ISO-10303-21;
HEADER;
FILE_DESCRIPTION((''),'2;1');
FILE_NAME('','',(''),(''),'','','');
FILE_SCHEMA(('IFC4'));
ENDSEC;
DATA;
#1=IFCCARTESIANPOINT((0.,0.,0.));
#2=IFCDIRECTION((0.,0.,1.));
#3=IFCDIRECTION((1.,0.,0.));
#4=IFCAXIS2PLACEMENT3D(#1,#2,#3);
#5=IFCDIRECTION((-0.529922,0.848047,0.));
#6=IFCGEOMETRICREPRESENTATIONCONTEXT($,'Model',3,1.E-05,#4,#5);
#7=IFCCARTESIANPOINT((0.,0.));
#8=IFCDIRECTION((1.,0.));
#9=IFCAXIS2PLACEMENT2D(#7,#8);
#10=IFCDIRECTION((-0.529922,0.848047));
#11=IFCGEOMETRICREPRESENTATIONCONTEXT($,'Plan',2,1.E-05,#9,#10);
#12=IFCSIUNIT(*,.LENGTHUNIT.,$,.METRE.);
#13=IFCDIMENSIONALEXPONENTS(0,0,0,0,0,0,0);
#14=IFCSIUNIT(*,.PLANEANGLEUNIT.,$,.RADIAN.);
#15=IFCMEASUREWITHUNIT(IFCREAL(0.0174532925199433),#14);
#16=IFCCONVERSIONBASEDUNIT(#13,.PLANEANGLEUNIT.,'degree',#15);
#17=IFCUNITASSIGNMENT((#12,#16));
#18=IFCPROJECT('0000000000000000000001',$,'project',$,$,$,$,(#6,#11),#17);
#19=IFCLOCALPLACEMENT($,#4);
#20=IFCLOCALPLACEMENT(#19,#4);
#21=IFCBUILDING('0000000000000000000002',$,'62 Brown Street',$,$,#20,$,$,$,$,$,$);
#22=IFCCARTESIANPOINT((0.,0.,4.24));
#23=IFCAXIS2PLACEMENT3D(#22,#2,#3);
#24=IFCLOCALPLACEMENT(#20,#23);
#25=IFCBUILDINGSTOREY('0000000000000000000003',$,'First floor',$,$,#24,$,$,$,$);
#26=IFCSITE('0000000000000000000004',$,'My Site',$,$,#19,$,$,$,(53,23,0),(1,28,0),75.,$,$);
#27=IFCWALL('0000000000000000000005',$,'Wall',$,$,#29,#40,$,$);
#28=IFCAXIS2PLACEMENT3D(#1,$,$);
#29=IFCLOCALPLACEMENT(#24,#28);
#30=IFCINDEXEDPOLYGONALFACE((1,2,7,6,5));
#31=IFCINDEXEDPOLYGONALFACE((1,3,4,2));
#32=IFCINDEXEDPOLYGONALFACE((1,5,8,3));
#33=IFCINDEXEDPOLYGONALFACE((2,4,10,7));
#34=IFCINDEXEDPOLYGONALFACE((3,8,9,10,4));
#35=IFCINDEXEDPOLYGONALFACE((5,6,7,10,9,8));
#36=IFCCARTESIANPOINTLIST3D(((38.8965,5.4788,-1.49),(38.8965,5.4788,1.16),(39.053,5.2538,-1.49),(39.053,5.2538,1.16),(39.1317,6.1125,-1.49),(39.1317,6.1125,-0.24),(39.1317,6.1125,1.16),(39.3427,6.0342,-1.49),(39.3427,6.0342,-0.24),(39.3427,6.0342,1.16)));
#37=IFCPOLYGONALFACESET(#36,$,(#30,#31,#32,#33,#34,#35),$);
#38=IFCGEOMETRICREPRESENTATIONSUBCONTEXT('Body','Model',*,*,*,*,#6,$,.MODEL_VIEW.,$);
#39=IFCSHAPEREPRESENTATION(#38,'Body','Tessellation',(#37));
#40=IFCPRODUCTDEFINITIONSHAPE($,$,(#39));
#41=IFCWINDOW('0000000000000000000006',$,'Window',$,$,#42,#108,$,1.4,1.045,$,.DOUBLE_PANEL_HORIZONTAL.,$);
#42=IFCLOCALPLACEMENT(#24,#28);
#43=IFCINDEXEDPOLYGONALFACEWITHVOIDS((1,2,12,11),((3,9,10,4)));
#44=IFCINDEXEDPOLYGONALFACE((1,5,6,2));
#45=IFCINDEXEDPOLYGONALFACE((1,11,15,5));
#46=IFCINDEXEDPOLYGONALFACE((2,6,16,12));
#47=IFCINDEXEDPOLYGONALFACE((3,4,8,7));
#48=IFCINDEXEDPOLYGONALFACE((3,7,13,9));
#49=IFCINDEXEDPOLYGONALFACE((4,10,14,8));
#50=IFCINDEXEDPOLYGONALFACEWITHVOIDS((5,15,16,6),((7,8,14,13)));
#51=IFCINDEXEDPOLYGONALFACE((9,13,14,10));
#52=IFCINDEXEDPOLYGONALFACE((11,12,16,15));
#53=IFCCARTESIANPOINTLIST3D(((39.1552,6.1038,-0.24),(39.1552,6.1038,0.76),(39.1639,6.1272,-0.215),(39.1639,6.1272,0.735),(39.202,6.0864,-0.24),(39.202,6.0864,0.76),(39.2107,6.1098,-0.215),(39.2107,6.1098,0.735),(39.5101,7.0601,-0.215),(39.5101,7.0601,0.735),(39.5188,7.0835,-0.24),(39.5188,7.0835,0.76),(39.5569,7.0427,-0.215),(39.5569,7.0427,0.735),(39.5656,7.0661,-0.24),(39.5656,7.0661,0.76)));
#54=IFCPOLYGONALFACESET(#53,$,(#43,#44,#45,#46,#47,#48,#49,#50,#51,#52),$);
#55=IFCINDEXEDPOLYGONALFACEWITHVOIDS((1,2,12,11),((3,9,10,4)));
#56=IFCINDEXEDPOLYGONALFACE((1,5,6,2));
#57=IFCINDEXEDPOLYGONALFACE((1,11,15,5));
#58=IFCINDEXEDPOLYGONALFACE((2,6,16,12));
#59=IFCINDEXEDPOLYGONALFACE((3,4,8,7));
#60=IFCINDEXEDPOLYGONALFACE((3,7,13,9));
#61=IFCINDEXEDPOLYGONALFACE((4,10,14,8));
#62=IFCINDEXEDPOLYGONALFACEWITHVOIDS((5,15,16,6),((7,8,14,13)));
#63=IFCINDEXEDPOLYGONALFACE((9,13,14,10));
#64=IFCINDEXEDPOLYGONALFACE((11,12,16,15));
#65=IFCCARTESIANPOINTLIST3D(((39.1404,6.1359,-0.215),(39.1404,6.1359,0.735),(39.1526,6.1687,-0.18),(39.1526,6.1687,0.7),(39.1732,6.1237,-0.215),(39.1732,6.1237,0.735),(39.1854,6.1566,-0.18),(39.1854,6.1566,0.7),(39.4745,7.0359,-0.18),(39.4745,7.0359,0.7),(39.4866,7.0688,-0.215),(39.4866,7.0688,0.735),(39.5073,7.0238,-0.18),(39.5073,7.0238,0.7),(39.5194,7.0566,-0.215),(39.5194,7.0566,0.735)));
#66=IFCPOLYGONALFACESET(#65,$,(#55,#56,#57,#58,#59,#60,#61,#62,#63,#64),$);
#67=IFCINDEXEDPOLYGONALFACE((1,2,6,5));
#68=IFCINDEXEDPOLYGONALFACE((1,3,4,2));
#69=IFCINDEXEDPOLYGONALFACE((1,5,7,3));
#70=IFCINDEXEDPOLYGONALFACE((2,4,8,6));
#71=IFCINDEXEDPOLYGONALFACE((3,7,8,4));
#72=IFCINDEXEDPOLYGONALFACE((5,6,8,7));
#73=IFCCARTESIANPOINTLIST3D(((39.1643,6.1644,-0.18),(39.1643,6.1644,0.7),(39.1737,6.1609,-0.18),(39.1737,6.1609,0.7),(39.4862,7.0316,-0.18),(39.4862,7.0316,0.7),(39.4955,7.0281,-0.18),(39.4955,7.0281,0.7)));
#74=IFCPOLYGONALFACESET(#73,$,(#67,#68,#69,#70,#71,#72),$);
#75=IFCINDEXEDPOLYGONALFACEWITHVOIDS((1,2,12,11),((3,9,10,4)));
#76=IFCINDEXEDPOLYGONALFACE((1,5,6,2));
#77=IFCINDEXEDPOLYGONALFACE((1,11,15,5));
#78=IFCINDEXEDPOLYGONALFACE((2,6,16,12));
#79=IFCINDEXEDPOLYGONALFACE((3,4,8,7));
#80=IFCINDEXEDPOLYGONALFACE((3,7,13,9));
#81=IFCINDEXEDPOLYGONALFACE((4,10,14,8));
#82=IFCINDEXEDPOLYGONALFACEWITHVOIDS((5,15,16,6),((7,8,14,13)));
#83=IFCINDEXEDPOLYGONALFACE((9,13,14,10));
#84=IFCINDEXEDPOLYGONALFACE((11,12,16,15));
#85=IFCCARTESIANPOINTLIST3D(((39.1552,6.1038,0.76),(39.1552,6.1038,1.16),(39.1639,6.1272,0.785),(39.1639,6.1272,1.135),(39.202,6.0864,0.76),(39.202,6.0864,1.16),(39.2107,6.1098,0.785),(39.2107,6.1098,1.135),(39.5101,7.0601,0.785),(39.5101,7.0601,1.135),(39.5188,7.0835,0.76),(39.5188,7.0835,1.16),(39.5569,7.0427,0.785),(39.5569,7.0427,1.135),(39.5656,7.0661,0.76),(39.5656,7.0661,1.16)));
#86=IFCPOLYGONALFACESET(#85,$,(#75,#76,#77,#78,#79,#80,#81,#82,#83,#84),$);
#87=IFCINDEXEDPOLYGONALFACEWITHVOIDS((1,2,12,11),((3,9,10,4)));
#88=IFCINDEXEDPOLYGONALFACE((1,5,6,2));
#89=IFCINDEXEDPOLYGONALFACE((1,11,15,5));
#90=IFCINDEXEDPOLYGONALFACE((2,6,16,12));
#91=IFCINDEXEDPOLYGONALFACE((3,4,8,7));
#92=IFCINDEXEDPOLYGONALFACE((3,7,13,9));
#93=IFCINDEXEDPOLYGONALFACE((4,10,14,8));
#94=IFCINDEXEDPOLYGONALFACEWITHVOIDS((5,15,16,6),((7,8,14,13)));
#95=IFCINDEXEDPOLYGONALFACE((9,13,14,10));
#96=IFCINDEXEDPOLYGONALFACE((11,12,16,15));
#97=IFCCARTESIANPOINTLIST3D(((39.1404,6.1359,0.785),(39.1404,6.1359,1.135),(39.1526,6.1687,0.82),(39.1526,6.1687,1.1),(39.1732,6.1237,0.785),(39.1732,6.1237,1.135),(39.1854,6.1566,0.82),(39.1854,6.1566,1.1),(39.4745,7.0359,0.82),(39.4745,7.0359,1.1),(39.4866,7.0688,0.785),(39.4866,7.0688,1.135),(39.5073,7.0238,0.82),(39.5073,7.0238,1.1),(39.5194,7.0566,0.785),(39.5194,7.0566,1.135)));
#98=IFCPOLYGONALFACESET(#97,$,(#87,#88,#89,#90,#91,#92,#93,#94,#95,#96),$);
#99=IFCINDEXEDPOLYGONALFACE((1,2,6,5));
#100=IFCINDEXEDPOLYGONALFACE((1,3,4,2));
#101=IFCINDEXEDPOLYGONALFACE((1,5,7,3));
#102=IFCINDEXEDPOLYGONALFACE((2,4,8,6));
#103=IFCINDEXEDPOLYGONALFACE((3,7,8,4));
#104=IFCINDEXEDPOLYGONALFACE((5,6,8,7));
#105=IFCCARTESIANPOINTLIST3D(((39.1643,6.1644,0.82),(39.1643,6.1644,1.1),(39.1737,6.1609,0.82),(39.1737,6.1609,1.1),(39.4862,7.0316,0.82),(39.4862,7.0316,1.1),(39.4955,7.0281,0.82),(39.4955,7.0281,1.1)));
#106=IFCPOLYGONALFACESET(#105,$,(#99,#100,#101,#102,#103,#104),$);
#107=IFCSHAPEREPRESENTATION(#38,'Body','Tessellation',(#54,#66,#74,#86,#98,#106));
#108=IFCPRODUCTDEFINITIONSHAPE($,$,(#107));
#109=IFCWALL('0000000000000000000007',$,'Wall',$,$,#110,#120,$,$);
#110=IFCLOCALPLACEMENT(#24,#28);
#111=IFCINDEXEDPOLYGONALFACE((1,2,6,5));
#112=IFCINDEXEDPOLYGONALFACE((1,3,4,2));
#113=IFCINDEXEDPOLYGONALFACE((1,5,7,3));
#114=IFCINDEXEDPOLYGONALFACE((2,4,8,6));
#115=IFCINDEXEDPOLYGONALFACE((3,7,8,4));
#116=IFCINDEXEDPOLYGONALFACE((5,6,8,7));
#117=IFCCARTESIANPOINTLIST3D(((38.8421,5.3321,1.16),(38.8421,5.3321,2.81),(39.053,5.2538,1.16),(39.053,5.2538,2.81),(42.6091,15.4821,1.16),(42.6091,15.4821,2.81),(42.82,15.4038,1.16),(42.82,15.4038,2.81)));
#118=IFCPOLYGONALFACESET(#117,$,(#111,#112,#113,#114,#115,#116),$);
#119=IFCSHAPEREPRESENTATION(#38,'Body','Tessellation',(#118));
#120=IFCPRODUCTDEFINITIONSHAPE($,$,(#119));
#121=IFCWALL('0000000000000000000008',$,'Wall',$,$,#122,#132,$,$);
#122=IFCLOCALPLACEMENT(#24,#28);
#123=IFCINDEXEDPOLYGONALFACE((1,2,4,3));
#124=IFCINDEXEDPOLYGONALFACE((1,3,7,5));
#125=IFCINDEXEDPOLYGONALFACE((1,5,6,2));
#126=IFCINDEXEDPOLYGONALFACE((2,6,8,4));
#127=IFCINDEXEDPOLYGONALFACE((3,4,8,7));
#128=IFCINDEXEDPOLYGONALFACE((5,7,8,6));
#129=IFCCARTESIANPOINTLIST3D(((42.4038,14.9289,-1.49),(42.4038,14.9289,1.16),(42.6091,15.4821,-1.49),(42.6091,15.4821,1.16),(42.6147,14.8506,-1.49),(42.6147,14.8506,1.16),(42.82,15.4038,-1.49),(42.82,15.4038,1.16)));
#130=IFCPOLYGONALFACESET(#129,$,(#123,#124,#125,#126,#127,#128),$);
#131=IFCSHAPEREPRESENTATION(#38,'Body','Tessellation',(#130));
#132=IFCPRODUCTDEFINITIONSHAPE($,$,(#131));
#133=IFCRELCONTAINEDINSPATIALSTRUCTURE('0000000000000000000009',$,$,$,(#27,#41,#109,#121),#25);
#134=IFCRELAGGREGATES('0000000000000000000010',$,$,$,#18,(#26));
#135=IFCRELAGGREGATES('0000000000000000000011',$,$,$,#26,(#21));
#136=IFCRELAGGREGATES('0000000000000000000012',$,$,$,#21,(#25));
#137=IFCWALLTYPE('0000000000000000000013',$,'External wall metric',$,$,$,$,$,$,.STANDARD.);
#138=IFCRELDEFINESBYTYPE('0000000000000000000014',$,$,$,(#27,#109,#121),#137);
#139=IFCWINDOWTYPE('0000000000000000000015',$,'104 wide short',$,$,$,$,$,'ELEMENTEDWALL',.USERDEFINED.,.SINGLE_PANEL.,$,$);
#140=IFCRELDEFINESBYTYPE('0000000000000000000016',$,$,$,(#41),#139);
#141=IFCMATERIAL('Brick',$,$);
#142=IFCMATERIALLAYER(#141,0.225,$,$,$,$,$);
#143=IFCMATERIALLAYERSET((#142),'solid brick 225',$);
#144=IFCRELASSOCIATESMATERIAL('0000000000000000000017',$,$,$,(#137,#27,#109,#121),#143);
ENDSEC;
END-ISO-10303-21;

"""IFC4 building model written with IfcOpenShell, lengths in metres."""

from ifc_helpers import new_model, entity, si_unit, converted_unit, direction, frame, origin_with_axes, origin_2d_with_axis, place, context, subcontext, project, spatial, line, indexed_curve, outline, extrude, clip, halfspace, shape, source, transform, mapped, material, layer, layer_set, layer_usage, type_object, type_shapes, element, fill, save


model = new_model("IFC4")

# Units and contexts
model_context = context("Model", 3, precision=1e-05, world=origin_with_axes(), true_north=direction((-0.529922, 0.848047, 0.0)))
plan_context = context("Plan", 2, precision=1e-05, world=origin_2d_with_axis(), true_north=direction((-0.529922, 0.848047)))
body_context_1 = subcontext(model_context, "Body", "Model", "MODEL_VIEW")
body_context_2 = subcontext(plan_context, "Body", "Plan", "PLAN_VIEW")
ifc_project = project(units=[si_unit("LENGTHUNIT", "METRE"), converted_unit("PLANEANGLEUNIT", "degree", entity("IfcReal", 0.0174532925199433), si_unit("PLANEANGLEUNIT", "RADIAN"), dimensions=[0, 0, 0, 0, 0, 0, 0])], contexts=[model_context, plan_context])

# Site, building, storey
site_placement = place(None, origin_with_axes())
site = spatial("IfcSite", under=ifc_project, at=site_placement, Name="My Site", RefLatitude=(53, 23, 0), RefLongitude=(1, 28, 0), RefElevation=75.0)
building_placement = place(site_placement, origin_with_axes())
building = spatial("IfcBuilding", under=site, at=building_placement, Name="62 Brown Street")
storey_placement = place(building_placement, frame((0.0, 0.0, 4.24), z_axis=(0.0, 0.0, 1.0), x_axis=(1.0, 0.0, 0.0)))
storey = spatial("IfcBuildingStorey", under=building, at=storey_placement, Name="First floor")

# Wall, opening, window
ifc_material_1 = material(Name="Brick")
ifc_layer_1 = layer(ifc_material_1, 0.225)
ifc_layer_set_1 = layer_set([ifc_layer_1], Name="solid brick 225")
ifc_layer_usage_1 = layer_usage(ifc_layer_set_1, "AXIS2", "POSITIVE", 0.0)
wall_type_1 = type_object("IfcWallType", Name="External wall metric", PredefinedType="STANDARD", material=ifc_layer_set_1)
wall_1_placement = place(storey_placement, frame((39.024, 5.1755, -1.49), z_axis=(0.0, 0.0, 1.0), x_axis=(0.347944, 0.937515, 0.0)))
wall_1 = element("IfcWall", 1, at=wall_1_placement, inside=storey, type_object=wall_type_1, material=ifc_layer_usage_1, Name="Wall", context=body_context_1, shape_type="Clipping", body=[
    clip(extrude(outline(indexed_curve([(0.0, 0.0), (0.0, 0.225), (0.9159, 0.225), (0.9159, 0.0), (0.0, 0.0)], self_intersect=False)), origin_with_axes(), (0.0, 0.0, 1.0), 2.65), halfspace(frame((0.0835, 0.0, -2.75), z_axis=(-0.596248, 0.414701, 0.0), x_axis=(0.156491, 0.224999, 0.0)), False)),
])
shared_shape_1 = source(origin_with_axes(), body_context_1, "Body", "SweptSolid", [
    extrude(outline(indexed_curve([(0.0, 0.0), (1.045, 0.0), (1.045, 1.4), (0.0, 1.4)], segments=[line(1, 2, 3, 4, 1)])), frame((0.0, -0.1, 0.0), z_axis=(0.0, -1.0, 0.0), x_axis=(1.0, 0.0, 0.0)), (0.0, 0.0, -1.0), 0.425),
])
opening_placement = place(wall_1_placement, frame((0.9159, 0.0, 1.25), z_axis=(0.0, 0.0, 1.0), x_axis=(1.0, 0.0, 0.0)))
opening = element("IfcOpeningElement", 2, at=opening_placement, cuts=wall_1, PredefinedType="OPENING", context=body_context_1, shape_type="MappedRepresentation", body=[
    mapped(shared_shape_1, transform((0.0, 0.0, 0.0), x_axis=(1.0, 0.0, 0.0), y_axis=(0.0, 1.0, 0.0), z_axis=(0.0, 0.0, 1.0), scale=1.0)),
])
window_type = type_object("IfcWindowType", Name="104 wide short", ElementType="ELEMENTEDWALL", PartitioningType="SINGLE_PANEL", PredefinedType="USERDEFINED")
shared_shape_2 = source(origin_with_axes(), body_context_1, "Body", "SweptSolid", [
    extrude(outline(indexed_curve([(0.0, 0.0), (1.045, 0.0), (1.045, 1.0), (0.0, 1.0)], segments=[line(1, 2, 3, 4, 1)]), holes=[indexed_curve([(0.025, 0.025), (1.02, 0.025), (1.02, 0.975), (0.025, 0.975)], segments=[line(1, 2, 3, 4, 1)])]), frame((0.0, 0.15, 0.0), z_axis=(0.0, -1.0, 0.0), x_axis=(1.0, 0.0, 0.0)), (0.0, 0.0, -1.0), 0.05),
    extrude(outline(indexed_curve([(0.0, 0.0), (0.995, 0.0), (0.995, 0.95), (0.0, 0.95)], segments=[line(1, 2, 3, 4, 1)]), holes=[indexed_curve([(0.035, 0.035), (0.96, 0.035), (0.96, 0.915), (0.035, 0.915)], segments=[line(1, 2, 3, 4, 1)])]), frame((0.025, 0.19, 0.025), z_axis=(0.0, -1.0, 0.0), x_axis=(1.0, 0.0, 0.0)), (0.0, 0.0, -1.0), 0.035),
    extrude(outline(indexed_curve([(0.035, 0.035), (0.96, 0.035), (0.96, 0.915), (0.035, 0.915)], segments=[line(1, 2, 3, 4, 1)])), frame((0.025, 0.2025, 0.025), z_axis=(0.0, -1.0, 0.0), x_axis=(1.0, 0.0, 0.0)), (0.0, 0.0, -1.0), 0.01),
    extrude(outline(indexed_curve([(0.0, 0.0), (1.045, 0.0), (1.045, 0.4), (0.0, 0.4)], segments=[line(1, 2, 3, 4, 1)]), holes=[indexed_curve([(0.025, 0.025), (1.02, 0.025), (1.02, 0.375), (0.025, 0.375)], segments=[line(1, 2, 3, 4, 1)])]), frame((0.0, 0.15, 1.0), z_axis=(0.0, -1.0, 0.0), x_axis=(1.0, 0.0, 0.0)), (0.0, 0.0, -1.0), 0.05),
    extrude(outline(indexed_curve([(0.0, 0.0), (0.995, 0.0), (0.995, 0.35), (0.0, 0.35)], segments=[line(1, 2, 3, 4, 1)]), holes=[indexed_curve([(0.035, 0.035), (0.96, 0.035), (0.96, 0.315), (0.035, 0.315)], segments=[line(1, 2, 3, 4, 1)])]), frame((0.025, 0.19, 1.025), z_axis=(0.0, -1.0, 0.0), x_axis=(1.0, 0.0, 0.0)), (0.0, 0.0, -1.0), 0.035),
    extrude(outline(indexed_curve([(0.035, 0.035), (0.96, 0.035), (0.96, 0.315), (0.035, 0.315)], segments=[line(1, 2, 3, 4, 1)])), frame((0.025, 0.2025, 1.025), z_axis=(0.0, -1.0, 0.0), x_axis=(1.0, 0.0, 0.0)), (0.0, 0.0, -1.0), 0.01),
])
shared_shape_3 = source(origin_with_axes(), body_context_2, "Body", "Curve2D", [
    entity("IfcIndexedPolyCurve", entity("IfcCartesianPointList2D", [[0.025, 0.15], [1.02, 0.15]])),
    entity("IfcIndexedPolyCurve", entity("IfcCartesianPointList2D", [[0.0, 0.2], [0.025, 0.2], [0.025, 0.15], [0.0, 0.15]]), [entity("IfcLineIndex", [1, 2, 3, 4, 1])]),
    entity("IfcIndexedPolyCurve", entity("IfcCartesianPointList2D", [[1.045, 0.2], [1.02, 0.2], [1.02, 0.15], [1.045, 0.15]]), [entity("IfcLineIndex", [1, 2, 3, 4, 1])]),
    entity("IfcIndexedPolyCurve", entity("IfcCartesianPointList2D", [[0.025, 0.19], [0.06, 0.19], [0.06, 0.225], [0.025, 0.225]]), [entity("IfcLineIndex", [1, 2, 3, 4, 1])]),
    entity("IfcIndexedPolyCurve", entity("IfcCartesianPointList2D", [[1.02, 0.19], [0.985, 0.19], [0.985, 0.225], [1.02, 0.225]]), [entity("IfcLineIndex", [1, 2, 3, 4, 1])]),
    entity("IfcIndexedPolyCurve", entity("IfcCartesianPointList2D", [[0.06, 0.19], [0.985, 0.19]])),
    entity("IfcIndexedPolyCurve", entity("IfcCartesianPointList2D", [[0.06, 0.225], [0.985, 0.225]])),
    entity("IfcIndexedPolyCurve", entity("IfcCartesianPointList2D", [[0.06, 0.2075], [0.985, 0.2075]])),
])
type_shapes(window_type, [shared_shape_2, shared_shape_3])
window_1_placement = place(opening_placement, frame((0.0, 0.0, 0.0), z_axis=(0.0, 0.0, 1.0), x_axis=(1.0, 0.0, 0.0)))
window_1 = element("IfcWindow", 3, at=window_1_placement, inside=storey, type_object=window_type, Name="Window", OverallHeight=1.4, OverallWidth=1.045, PartitioningType="DOUBLE_PANEL_HORIZONTAL", shapes=[
    shape(body_context_1, "Body", "MappedRepresentation", [mapped(shared_shape_2, transform((0.0, 0.0, 0.0), x_axis=(1.0, 0.0, 0.0), y_axis=(0.0, 1.0, 0.0), z_axis=(0.0, 0.0, 1.0), scale=1.0))]),
    shape(body_context_2, "Body", "MappedRepresentation", [mapped(shared_shape_3, transform((0.0, 0.0, 0.0), x_axis=(1.0, 0.0, 0.0), y_axis=(0.0, 1.0, 0.0), z_axis=(0.0, 0.0, 1.0), scale=1.0))]),
])
fill(opening, window_1)

# Walls
ifc_layer_usage_2 = layer_usage(ifc_layer_set_1, "AXIS2", "POSITIVE", 0.0)
wall_2_placement = place(storey_placement, frame((39.053, 5.2538, 1.16), z_axis=(0.0, 0.0, 1.0), x_axis=(0.347944, 0.937515, 0.0)))
element("IfcWall", 4, at=wall_2_placement, inside=storey, type_object=wall_type_1, material=ifc_layer_usage_2, Name="Wall", context=body_context_1, shape_type="SweptSolid", body=[
    extrude(outline(indexed_curve([(0.0, 0.0), (0.0, 0.225), (10.8265, 0.225), (10.8265, 0.0), (0.0, 0.0)], self_intersect=False)), origin_with_axes(), (0.0, 0.0, 1.0), 1.65),
])
ifc_layer_usage_3 = layer_usage(ifc_layer_set_1, "AXIS2", "POSITIVE", 0.0)
wall_3_placement = place(storey_placement, frame((42.6147, 14.8506, -1.49), z_axis=(0.0, 0.0, 1.0), x_axis=(0.347944, 0.937515, 0.0)))
element("IfcWall", 5, at=wall_3_placement, inside=storey, type_object=wall_type_1, material=ifc_layer_usage_3, Name="Wall", context=body_context_1, shape_type="SweptSolid", body=[
    extrude(outline(indexed_curve([(0.0, 0.0), (0.0, 0.225), (0.5901, 0.225), (0.5901, 0.0), (0.0, 0.0)], self_intersect=False)), origin_with_axes(), (0.0, 0.0, 1.0), 2.65),
])

save(model, "model.ifc")
